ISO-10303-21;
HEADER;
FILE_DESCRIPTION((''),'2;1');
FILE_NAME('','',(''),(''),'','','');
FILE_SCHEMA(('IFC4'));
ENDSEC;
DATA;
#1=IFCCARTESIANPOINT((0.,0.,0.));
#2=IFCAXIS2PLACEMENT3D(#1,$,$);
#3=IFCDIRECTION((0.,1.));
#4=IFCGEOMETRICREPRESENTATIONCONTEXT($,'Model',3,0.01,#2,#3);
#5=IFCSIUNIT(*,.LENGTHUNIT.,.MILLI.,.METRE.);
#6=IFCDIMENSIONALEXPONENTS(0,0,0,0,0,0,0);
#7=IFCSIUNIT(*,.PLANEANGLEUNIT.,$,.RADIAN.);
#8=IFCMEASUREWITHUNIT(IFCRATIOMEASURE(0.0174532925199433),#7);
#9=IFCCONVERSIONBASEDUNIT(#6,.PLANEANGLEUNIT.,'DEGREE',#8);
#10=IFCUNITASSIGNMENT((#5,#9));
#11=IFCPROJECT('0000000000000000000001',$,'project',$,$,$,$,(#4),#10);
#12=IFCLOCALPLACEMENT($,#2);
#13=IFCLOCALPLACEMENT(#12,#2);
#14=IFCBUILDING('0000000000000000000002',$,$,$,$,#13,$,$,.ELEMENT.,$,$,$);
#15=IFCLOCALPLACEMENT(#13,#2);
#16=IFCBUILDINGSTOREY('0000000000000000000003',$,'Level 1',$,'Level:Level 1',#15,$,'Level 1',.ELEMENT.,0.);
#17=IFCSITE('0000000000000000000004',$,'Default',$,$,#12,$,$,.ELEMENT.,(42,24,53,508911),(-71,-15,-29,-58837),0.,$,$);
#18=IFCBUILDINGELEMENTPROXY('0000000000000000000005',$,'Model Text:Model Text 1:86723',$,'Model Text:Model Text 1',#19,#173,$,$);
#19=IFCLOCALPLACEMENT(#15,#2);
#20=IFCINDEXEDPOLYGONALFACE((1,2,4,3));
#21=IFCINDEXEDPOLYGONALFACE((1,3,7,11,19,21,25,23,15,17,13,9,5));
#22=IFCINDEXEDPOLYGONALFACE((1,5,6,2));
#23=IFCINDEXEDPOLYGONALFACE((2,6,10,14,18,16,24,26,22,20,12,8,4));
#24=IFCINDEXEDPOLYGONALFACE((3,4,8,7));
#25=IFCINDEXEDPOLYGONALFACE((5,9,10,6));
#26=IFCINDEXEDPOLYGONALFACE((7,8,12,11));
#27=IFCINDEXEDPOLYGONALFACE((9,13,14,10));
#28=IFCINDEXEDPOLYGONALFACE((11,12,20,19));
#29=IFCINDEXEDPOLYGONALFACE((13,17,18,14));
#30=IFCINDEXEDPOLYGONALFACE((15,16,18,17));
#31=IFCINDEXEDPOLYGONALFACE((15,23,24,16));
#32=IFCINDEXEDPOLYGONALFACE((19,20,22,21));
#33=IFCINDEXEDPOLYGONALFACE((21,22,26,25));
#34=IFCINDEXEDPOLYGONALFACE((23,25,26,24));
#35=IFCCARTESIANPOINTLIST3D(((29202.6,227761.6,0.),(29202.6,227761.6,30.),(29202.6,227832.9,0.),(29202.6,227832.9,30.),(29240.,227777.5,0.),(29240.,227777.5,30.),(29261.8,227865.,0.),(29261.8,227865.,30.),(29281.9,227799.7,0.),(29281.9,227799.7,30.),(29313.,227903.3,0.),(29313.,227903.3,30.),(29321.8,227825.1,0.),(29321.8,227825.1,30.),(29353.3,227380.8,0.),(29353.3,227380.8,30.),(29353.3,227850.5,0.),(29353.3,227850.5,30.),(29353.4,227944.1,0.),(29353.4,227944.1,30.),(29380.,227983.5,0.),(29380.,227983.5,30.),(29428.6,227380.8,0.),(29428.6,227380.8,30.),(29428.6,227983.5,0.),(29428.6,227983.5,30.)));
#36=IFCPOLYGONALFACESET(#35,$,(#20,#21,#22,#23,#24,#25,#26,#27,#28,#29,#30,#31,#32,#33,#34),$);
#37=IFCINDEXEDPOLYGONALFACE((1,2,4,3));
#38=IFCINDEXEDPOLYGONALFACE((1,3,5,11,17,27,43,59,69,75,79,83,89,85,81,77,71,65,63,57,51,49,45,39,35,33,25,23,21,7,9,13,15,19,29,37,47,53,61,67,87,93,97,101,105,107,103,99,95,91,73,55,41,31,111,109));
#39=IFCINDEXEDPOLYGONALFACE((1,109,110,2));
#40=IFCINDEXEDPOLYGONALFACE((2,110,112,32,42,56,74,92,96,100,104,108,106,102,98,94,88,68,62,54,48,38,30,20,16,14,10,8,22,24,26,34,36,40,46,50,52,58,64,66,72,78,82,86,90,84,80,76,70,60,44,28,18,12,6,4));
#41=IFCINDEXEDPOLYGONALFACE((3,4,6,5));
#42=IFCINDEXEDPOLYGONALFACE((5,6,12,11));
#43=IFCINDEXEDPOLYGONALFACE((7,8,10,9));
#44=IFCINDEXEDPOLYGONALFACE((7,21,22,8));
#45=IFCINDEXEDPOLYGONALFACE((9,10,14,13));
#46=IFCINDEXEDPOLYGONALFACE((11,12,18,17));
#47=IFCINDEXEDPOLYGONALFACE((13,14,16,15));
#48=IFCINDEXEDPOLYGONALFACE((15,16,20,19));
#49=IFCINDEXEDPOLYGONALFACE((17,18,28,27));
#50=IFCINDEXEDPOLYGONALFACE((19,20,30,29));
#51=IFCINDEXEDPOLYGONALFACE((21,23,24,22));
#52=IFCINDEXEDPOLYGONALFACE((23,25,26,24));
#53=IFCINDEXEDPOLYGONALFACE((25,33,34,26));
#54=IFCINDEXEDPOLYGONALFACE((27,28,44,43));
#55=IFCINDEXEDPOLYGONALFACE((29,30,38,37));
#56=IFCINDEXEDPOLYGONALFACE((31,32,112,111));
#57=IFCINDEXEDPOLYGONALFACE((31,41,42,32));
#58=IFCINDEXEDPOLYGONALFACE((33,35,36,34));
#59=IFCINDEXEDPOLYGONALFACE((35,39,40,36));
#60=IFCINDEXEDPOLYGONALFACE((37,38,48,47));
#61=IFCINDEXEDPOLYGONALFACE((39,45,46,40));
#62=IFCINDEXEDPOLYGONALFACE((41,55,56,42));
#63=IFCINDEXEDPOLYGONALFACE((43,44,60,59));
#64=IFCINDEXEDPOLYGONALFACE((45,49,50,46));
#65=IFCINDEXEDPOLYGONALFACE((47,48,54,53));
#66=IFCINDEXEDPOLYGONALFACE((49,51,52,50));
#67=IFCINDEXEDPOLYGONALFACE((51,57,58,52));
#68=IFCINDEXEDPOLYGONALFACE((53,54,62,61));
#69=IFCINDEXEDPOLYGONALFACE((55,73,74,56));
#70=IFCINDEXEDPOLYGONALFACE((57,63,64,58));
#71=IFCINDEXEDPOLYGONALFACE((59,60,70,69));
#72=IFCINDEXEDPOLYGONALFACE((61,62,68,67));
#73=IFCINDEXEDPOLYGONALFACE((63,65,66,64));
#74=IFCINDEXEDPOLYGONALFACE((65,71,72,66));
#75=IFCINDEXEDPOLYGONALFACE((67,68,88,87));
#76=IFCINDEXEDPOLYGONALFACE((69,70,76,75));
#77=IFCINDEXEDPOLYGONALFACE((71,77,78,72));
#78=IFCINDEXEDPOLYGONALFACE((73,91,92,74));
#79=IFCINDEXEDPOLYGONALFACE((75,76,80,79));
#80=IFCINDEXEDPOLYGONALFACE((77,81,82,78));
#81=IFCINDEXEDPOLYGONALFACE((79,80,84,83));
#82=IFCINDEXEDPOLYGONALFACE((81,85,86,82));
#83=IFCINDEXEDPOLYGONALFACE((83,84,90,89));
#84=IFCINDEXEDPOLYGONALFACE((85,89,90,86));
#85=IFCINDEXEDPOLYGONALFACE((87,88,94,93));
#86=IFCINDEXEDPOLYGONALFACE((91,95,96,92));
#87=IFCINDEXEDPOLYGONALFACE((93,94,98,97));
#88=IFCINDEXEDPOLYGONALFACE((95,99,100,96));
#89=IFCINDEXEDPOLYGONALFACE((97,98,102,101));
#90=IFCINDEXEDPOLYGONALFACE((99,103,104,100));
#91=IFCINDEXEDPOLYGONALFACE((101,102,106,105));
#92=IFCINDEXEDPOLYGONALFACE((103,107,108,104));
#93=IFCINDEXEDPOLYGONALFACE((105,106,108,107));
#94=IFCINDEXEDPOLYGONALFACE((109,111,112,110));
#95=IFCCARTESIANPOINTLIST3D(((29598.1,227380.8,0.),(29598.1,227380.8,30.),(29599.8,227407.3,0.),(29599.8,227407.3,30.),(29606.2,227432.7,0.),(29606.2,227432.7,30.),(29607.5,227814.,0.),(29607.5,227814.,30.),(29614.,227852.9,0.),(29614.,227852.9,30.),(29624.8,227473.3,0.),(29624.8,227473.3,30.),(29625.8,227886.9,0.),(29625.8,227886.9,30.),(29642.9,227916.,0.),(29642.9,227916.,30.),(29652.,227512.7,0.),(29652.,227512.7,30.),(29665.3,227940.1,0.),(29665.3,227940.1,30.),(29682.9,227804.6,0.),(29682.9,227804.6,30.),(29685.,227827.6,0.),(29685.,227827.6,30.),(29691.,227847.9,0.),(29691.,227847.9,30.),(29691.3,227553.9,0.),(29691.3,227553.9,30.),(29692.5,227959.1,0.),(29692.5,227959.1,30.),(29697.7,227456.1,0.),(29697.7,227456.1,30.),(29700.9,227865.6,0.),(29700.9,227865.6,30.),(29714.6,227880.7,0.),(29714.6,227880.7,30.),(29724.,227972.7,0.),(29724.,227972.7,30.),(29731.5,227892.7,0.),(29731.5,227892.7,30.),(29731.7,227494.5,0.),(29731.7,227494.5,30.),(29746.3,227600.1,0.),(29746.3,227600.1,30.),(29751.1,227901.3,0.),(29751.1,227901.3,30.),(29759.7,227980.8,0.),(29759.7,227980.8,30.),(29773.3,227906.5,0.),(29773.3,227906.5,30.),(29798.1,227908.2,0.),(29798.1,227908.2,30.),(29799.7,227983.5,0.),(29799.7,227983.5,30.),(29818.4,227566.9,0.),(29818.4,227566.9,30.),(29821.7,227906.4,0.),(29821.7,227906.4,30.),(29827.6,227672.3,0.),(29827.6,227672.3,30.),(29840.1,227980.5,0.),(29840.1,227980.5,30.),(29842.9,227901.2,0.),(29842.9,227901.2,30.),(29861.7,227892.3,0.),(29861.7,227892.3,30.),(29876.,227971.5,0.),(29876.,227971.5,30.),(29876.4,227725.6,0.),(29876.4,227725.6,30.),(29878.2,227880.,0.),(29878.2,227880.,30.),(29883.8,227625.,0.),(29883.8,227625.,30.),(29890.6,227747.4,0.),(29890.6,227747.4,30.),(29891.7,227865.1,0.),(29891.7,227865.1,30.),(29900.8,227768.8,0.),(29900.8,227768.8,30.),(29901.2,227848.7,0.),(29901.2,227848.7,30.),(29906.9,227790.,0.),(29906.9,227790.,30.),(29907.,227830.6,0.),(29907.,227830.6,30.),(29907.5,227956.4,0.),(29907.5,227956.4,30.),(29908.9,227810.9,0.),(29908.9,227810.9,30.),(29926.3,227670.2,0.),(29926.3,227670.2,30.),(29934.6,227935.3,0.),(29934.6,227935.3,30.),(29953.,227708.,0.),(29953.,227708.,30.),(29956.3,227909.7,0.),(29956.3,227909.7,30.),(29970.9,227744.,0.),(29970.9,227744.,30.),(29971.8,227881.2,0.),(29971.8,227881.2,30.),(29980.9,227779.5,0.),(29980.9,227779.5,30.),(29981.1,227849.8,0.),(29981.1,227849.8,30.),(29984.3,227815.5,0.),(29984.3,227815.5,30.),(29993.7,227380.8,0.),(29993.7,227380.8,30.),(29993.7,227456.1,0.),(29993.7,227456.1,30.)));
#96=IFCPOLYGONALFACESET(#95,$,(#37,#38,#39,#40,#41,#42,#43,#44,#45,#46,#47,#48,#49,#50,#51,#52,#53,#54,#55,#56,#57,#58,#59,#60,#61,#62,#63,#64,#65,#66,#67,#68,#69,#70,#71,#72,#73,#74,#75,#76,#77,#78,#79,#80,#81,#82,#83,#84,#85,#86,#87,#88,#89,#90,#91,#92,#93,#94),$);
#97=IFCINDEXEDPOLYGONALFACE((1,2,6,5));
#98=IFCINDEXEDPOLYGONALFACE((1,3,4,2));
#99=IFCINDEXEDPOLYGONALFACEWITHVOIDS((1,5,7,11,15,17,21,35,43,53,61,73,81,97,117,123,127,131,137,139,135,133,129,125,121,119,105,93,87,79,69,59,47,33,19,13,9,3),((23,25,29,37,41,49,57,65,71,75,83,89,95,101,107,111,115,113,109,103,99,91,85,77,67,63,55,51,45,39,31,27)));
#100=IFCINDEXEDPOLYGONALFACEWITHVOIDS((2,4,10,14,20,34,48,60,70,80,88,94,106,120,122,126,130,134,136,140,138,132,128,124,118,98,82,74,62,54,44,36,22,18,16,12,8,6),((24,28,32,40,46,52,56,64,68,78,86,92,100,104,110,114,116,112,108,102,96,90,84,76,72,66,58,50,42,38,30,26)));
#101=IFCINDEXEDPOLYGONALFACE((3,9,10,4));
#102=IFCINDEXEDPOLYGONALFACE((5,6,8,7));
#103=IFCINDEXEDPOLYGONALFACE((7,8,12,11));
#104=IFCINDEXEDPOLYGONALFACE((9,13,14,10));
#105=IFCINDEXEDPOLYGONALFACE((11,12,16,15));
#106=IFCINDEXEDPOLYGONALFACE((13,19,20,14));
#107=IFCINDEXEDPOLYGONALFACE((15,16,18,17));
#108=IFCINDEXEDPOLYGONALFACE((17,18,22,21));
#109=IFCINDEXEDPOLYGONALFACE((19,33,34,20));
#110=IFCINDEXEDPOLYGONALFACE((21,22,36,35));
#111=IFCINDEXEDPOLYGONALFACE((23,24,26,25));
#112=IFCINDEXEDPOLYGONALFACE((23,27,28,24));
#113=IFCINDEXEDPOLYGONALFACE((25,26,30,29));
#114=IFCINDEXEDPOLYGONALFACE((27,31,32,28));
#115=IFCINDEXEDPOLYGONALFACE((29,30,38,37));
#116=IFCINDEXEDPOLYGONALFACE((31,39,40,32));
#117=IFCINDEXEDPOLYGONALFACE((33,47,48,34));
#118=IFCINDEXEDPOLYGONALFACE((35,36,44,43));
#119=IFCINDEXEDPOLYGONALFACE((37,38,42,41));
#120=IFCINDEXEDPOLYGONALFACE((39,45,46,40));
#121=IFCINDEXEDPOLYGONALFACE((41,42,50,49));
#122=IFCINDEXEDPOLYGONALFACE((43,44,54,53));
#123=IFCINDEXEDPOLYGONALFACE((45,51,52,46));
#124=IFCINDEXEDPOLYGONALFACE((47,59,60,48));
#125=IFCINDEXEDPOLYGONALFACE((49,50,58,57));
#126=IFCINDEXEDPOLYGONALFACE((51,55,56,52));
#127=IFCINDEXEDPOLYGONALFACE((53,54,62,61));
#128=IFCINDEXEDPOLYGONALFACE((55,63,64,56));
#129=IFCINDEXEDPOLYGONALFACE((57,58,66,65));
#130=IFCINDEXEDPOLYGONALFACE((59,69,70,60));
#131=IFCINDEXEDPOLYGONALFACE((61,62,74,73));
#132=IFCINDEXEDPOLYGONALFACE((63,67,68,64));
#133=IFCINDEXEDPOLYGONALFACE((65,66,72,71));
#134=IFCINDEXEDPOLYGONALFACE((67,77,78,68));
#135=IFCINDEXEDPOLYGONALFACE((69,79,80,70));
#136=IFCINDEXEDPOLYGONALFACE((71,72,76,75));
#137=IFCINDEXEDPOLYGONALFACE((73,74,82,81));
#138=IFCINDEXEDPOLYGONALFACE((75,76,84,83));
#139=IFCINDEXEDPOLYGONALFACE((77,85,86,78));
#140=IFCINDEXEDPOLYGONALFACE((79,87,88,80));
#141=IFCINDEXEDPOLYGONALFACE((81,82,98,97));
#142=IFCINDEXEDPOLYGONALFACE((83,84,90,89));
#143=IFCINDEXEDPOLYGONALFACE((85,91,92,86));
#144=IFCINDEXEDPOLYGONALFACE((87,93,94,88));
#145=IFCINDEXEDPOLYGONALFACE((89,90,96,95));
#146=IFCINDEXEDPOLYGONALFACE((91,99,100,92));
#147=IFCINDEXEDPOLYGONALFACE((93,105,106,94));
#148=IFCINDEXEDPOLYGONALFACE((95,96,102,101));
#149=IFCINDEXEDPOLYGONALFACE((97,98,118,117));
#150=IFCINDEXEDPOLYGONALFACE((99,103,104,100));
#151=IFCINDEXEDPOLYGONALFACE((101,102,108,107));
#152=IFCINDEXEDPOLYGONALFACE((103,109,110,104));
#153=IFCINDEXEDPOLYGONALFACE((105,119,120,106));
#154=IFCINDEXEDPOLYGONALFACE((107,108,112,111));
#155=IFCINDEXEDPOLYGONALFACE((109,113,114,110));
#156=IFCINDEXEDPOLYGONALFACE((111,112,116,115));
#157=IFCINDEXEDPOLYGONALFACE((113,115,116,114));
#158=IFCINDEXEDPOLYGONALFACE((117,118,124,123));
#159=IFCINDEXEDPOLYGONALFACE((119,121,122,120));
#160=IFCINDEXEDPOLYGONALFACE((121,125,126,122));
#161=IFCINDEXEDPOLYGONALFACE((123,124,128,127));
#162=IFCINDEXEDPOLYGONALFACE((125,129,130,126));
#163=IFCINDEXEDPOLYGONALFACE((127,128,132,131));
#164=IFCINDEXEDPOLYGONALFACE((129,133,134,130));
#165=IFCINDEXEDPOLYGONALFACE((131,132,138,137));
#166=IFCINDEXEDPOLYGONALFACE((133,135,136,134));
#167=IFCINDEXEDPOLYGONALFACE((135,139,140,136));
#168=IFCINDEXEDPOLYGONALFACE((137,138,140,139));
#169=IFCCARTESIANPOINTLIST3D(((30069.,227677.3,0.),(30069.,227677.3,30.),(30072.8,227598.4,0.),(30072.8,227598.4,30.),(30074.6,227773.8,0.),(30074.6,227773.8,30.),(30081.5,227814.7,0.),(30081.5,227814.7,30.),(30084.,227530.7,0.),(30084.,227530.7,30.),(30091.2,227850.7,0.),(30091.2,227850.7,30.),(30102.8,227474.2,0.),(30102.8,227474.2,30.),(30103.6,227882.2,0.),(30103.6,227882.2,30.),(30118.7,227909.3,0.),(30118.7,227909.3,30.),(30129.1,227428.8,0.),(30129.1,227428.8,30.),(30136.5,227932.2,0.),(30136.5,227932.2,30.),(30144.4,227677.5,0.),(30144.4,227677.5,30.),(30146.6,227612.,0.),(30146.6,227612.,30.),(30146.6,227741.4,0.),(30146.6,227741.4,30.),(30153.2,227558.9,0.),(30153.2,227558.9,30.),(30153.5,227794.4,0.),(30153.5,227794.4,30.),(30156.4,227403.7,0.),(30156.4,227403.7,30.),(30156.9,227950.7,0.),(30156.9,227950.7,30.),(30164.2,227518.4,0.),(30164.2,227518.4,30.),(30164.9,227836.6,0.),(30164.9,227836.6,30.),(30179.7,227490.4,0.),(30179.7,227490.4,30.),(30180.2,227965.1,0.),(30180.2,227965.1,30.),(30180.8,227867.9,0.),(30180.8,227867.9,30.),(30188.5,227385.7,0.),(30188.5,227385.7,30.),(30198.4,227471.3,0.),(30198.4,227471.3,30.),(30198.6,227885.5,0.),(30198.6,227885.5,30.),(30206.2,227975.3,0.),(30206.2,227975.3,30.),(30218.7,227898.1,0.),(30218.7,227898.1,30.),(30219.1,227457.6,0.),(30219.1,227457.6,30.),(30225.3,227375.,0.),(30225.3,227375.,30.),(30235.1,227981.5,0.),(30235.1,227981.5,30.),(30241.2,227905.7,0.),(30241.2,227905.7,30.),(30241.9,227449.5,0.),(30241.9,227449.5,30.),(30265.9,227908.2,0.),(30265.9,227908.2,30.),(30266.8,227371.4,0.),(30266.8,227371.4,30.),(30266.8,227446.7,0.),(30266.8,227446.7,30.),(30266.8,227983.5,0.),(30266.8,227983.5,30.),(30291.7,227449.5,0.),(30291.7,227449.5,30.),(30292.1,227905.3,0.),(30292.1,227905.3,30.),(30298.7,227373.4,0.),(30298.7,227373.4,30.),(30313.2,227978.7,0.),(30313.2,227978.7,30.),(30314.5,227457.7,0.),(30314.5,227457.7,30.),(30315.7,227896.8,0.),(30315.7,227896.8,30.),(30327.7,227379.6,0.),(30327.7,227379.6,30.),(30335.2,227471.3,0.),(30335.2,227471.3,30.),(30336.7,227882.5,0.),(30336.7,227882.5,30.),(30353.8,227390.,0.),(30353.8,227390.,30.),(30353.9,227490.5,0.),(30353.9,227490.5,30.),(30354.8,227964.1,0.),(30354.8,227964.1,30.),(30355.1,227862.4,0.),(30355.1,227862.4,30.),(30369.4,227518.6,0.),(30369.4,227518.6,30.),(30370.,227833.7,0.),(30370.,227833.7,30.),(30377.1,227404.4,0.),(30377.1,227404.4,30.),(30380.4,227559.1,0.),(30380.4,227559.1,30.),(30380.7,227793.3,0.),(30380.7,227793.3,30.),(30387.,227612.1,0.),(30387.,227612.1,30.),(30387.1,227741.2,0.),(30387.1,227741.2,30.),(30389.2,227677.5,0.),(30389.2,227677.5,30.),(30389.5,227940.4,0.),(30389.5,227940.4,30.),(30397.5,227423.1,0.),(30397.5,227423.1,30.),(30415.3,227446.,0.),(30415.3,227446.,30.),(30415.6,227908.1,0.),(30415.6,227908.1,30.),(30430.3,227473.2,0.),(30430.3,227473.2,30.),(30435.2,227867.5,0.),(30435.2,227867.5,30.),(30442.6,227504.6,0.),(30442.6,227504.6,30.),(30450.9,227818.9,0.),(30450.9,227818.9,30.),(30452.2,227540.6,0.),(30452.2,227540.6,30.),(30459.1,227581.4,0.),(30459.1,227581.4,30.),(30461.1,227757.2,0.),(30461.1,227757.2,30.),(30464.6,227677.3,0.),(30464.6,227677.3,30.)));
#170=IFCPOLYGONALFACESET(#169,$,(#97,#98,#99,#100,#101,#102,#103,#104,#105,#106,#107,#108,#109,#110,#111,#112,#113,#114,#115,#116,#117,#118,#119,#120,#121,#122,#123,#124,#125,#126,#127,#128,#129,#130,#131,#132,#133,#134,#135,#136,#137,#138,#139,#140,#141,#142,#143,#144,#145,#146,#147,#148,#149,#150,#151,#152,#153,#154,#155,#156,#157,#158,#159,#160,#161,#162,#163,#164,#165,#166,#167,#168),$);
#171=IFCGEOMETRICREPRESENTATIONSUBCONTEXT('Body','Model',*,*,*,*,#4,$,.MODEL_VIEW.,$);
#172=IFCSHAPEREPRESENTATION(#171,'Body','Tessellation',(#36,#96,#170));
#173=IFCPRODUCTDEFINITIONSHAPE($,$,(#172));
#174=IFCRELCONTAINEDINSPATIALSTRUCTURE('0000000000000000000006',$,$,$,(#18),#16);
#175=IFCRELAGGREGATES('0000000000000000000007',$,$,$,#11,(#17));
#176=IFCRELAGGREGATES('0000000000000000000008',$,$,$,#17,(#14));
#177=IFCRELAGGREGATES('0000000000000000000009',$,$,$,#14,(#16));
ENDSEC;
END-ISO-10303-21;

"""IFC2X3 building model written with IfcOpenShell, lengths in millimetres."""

from ifc_helpers import new_model, entity, si_unit, converted_unit, direction, frame, origin, place, context, subcontext, project, spatial, polyline, outline, extrude, element, save


model = new_model("IFC2X3")

# Units and contexts
model_context = context("Model", 3, precision=0.01, world=origin(), true_north=direction((0.0, 1.0)))
body_context = subcontext(model_context, "Body", "Model", "MODEL_VIEW")
ifc_project = project(units=[si_unit("LENGTHUNIT", "METRE", prefix="MILLI"), converted_unit("PLANEANGLEUNIT", "DEGREE", entity("IfcRatioMeasure", 0.0174532925199433), si_unit("PLANEANGLEUNIT", "RADIAN"), dimensions=[0, 0, 0, 0, 0, 0, 0])], contexts=[model_context])

# Site, building, storey
site_placement = place(None, origin())
site = spatial("IfcSite", under=ifc_project, at=site_placement, Name="Default", CompositionType="ELEMENT", RefLatitude=(42, 24, 53, 508911), RefLongitude=(-71, -15, -29, -58837), RefElevation=0.0)
building_placement = place(site_placement, origin())
building = spatial("IfcBuilding", under=site, at=building_placement, CompositionType="ELEMENT")
storey_placement = place(building_placement, origin())
storey = spatial("IfcBuildingStorey", under=building, at=storey_placement, Name="Level 1", ObjectType="Level:Level 1", LongName="Level 1", CompositionType="ELEMENT", Elevation=0.0)

# Building element proxy
proxy_1_placement = place(storey_placement, origin())
element("IfcBuildingElementProxy", 1, at=proxy_1_placement, inside=storey, Name="Model Text:Model Text 1:86723", ObjectType="Model Text:Model Text 1", context=body_context, shape_type="SweptSolid", body=[
    extrude(outline(polyline([(-410.6, -111.6), (192.1, -111.6), (192.1, -63.1), (152.7, -36.4), (111.9, 4.0), (73.6, 55.2), (41.4, 114.4), (-29.8, 114.4), (-13.9, 77.0), (8.3, 35.1), (33.7, -4.8), (59.1, -36.3), (-410.6, -36.3), (-410.6, -111.6)])), frame((29317.0, 227791.4, 0.0), z_axis=(0.0, 0.0, 1.0), x_axis=(0.0, 1.0, 0.0)), (0.0, 0.0, 1.0), 30.0),
    extrude(outline(polyline([(-190.2, -317.5), (-190.2, -392.8), (205.4, -392.8), (203.7, -366.3), (197.3, -340.9), (178.7, -300.3), (151.5, -260.9), (112.2, -219.7), (57.2, -173.6), (-24.1, -101.3), (-72.9, -48.0), (-87.1, -26.3), (-97.3, -4.8), (-103.4, 16.4), (-105.4, 37.3), (-103.5, 57.0), (-97.7, 75.0), (-88.2, 91.5), (-74.7, 106.4), (-58.2, 118.7), (-39.4, 127.5), (-18.2, 132.8), (5.4, 134.6), (30.2, 132.9), (52.4, 127.7), (72.0, 119.1), (88.9, 107.1), (102.6, 92.0), (112.5, 74.3), (118.5, 54.0), (120.6, 31.0), (196.0, 40.4), (189.5, 79.3), (177.7, 113.3), (160.6, 142.4), (138.2, 166.5), (111.0, 185.5), (79.5, 199.1), (43.8, 207.2), (3.8, 209.9), (-36.6, 206.9), (-72.5, 197.9), (-104.0, 182.8), (-131.1, 161.7), (-152.8, 136.1), (-168.3, 107.6), (-177.6, 76.2), (-180.8, 41.9), (-177.4, 5.8), (-167.4, -29.6), (-149.5, -65.6), (-122.8, -103.4), (-80.3, -148.6), (-14.9, -206.7), (71.8, -279.1), (105.8, -317.5), (-190.2, -317.5)])), frame((29803.5, 227773.6, 0.0), z_axis=(0.0, 0.0, -1.0), x_axis=(-1.0, 0.0, 0.0)), (0.0, 0.0, -1.0), 30.0),
    extrude(outline(polyline([(-10.6, -198.7), (68.3, -198.7), (136.5, -190.7), (193.9, -174.7), (240.5, -150.6), (266.9, -124.4), (286.3, -93.2), (298.8, -57.0), (304.3, -15.7), (303.8, 16.2), (299.0, 45.5), (289.9, 72.1), (276.6, 96.0), (258.9, 117.3), (236.9, 136.2), (210.4, 152.5), (179.6, 166.3), (144.1, 177.6), (103.7, 186.3), (8.2, 196.4), (-71.8, 196.7), (-134.0, 189.4), (-183.3, 176.1), (-224.7, 158.4), (-258.2, 133.9), (-283.5, 100.3), (-300.1, 59.5), (-307.1, 13.4), (-306.6, -18.4), (-301.8, -47.5), (-292.8, -74.0), (-279.6, -97.9), (-262.0, -119.2), (-240.0, -138.1), (-213.6, -154.5), (-182.8, -168.4), (-147.3, -179.8), (-106.7, -188.6), (-10.6, -198.7)]), holes=[polyline([(-7.2, -123.5), (-71.0, -118.2), (-123.6, -108.8), (-165.2, -95.4), (-195.7, -78.0), (-212.4, -59.4), (-224.1, -38.7), (-230.6, -15.9), (-231.9, 8.9), (-227.8, 35.0), (-218.1, 58.1), (-202.8, 78.4), (-182.0, 95.8), (-152.6, 109.4), (-111.7, 118.1), (-59.4, 122.0), (4.4, 121.1), (69.6, 115.8), (122.2, 106.7), (162.2, 93.7), (189.5, 77.0), (207.7, 57.4), (220.4, 36.0), (227.5, 12.8), (229.1, -12.1), (225.2, -36.8), (215.9, -59.2), (201.3, -79.3), (181.4, -97.1), (152.6, -111.2), (111.6, -120.3), (58.3, -124.4), (-7.2, -123.5)])]), frame((30268.0, 227676.1, 0.0), z_axis=(0.0, 0.0, 1.0), x_axis=(0.047515, -0.998871, 0.0)), (0.0, 0.0, 1.0), 30.0),
])

save(model, "model.ifc")
